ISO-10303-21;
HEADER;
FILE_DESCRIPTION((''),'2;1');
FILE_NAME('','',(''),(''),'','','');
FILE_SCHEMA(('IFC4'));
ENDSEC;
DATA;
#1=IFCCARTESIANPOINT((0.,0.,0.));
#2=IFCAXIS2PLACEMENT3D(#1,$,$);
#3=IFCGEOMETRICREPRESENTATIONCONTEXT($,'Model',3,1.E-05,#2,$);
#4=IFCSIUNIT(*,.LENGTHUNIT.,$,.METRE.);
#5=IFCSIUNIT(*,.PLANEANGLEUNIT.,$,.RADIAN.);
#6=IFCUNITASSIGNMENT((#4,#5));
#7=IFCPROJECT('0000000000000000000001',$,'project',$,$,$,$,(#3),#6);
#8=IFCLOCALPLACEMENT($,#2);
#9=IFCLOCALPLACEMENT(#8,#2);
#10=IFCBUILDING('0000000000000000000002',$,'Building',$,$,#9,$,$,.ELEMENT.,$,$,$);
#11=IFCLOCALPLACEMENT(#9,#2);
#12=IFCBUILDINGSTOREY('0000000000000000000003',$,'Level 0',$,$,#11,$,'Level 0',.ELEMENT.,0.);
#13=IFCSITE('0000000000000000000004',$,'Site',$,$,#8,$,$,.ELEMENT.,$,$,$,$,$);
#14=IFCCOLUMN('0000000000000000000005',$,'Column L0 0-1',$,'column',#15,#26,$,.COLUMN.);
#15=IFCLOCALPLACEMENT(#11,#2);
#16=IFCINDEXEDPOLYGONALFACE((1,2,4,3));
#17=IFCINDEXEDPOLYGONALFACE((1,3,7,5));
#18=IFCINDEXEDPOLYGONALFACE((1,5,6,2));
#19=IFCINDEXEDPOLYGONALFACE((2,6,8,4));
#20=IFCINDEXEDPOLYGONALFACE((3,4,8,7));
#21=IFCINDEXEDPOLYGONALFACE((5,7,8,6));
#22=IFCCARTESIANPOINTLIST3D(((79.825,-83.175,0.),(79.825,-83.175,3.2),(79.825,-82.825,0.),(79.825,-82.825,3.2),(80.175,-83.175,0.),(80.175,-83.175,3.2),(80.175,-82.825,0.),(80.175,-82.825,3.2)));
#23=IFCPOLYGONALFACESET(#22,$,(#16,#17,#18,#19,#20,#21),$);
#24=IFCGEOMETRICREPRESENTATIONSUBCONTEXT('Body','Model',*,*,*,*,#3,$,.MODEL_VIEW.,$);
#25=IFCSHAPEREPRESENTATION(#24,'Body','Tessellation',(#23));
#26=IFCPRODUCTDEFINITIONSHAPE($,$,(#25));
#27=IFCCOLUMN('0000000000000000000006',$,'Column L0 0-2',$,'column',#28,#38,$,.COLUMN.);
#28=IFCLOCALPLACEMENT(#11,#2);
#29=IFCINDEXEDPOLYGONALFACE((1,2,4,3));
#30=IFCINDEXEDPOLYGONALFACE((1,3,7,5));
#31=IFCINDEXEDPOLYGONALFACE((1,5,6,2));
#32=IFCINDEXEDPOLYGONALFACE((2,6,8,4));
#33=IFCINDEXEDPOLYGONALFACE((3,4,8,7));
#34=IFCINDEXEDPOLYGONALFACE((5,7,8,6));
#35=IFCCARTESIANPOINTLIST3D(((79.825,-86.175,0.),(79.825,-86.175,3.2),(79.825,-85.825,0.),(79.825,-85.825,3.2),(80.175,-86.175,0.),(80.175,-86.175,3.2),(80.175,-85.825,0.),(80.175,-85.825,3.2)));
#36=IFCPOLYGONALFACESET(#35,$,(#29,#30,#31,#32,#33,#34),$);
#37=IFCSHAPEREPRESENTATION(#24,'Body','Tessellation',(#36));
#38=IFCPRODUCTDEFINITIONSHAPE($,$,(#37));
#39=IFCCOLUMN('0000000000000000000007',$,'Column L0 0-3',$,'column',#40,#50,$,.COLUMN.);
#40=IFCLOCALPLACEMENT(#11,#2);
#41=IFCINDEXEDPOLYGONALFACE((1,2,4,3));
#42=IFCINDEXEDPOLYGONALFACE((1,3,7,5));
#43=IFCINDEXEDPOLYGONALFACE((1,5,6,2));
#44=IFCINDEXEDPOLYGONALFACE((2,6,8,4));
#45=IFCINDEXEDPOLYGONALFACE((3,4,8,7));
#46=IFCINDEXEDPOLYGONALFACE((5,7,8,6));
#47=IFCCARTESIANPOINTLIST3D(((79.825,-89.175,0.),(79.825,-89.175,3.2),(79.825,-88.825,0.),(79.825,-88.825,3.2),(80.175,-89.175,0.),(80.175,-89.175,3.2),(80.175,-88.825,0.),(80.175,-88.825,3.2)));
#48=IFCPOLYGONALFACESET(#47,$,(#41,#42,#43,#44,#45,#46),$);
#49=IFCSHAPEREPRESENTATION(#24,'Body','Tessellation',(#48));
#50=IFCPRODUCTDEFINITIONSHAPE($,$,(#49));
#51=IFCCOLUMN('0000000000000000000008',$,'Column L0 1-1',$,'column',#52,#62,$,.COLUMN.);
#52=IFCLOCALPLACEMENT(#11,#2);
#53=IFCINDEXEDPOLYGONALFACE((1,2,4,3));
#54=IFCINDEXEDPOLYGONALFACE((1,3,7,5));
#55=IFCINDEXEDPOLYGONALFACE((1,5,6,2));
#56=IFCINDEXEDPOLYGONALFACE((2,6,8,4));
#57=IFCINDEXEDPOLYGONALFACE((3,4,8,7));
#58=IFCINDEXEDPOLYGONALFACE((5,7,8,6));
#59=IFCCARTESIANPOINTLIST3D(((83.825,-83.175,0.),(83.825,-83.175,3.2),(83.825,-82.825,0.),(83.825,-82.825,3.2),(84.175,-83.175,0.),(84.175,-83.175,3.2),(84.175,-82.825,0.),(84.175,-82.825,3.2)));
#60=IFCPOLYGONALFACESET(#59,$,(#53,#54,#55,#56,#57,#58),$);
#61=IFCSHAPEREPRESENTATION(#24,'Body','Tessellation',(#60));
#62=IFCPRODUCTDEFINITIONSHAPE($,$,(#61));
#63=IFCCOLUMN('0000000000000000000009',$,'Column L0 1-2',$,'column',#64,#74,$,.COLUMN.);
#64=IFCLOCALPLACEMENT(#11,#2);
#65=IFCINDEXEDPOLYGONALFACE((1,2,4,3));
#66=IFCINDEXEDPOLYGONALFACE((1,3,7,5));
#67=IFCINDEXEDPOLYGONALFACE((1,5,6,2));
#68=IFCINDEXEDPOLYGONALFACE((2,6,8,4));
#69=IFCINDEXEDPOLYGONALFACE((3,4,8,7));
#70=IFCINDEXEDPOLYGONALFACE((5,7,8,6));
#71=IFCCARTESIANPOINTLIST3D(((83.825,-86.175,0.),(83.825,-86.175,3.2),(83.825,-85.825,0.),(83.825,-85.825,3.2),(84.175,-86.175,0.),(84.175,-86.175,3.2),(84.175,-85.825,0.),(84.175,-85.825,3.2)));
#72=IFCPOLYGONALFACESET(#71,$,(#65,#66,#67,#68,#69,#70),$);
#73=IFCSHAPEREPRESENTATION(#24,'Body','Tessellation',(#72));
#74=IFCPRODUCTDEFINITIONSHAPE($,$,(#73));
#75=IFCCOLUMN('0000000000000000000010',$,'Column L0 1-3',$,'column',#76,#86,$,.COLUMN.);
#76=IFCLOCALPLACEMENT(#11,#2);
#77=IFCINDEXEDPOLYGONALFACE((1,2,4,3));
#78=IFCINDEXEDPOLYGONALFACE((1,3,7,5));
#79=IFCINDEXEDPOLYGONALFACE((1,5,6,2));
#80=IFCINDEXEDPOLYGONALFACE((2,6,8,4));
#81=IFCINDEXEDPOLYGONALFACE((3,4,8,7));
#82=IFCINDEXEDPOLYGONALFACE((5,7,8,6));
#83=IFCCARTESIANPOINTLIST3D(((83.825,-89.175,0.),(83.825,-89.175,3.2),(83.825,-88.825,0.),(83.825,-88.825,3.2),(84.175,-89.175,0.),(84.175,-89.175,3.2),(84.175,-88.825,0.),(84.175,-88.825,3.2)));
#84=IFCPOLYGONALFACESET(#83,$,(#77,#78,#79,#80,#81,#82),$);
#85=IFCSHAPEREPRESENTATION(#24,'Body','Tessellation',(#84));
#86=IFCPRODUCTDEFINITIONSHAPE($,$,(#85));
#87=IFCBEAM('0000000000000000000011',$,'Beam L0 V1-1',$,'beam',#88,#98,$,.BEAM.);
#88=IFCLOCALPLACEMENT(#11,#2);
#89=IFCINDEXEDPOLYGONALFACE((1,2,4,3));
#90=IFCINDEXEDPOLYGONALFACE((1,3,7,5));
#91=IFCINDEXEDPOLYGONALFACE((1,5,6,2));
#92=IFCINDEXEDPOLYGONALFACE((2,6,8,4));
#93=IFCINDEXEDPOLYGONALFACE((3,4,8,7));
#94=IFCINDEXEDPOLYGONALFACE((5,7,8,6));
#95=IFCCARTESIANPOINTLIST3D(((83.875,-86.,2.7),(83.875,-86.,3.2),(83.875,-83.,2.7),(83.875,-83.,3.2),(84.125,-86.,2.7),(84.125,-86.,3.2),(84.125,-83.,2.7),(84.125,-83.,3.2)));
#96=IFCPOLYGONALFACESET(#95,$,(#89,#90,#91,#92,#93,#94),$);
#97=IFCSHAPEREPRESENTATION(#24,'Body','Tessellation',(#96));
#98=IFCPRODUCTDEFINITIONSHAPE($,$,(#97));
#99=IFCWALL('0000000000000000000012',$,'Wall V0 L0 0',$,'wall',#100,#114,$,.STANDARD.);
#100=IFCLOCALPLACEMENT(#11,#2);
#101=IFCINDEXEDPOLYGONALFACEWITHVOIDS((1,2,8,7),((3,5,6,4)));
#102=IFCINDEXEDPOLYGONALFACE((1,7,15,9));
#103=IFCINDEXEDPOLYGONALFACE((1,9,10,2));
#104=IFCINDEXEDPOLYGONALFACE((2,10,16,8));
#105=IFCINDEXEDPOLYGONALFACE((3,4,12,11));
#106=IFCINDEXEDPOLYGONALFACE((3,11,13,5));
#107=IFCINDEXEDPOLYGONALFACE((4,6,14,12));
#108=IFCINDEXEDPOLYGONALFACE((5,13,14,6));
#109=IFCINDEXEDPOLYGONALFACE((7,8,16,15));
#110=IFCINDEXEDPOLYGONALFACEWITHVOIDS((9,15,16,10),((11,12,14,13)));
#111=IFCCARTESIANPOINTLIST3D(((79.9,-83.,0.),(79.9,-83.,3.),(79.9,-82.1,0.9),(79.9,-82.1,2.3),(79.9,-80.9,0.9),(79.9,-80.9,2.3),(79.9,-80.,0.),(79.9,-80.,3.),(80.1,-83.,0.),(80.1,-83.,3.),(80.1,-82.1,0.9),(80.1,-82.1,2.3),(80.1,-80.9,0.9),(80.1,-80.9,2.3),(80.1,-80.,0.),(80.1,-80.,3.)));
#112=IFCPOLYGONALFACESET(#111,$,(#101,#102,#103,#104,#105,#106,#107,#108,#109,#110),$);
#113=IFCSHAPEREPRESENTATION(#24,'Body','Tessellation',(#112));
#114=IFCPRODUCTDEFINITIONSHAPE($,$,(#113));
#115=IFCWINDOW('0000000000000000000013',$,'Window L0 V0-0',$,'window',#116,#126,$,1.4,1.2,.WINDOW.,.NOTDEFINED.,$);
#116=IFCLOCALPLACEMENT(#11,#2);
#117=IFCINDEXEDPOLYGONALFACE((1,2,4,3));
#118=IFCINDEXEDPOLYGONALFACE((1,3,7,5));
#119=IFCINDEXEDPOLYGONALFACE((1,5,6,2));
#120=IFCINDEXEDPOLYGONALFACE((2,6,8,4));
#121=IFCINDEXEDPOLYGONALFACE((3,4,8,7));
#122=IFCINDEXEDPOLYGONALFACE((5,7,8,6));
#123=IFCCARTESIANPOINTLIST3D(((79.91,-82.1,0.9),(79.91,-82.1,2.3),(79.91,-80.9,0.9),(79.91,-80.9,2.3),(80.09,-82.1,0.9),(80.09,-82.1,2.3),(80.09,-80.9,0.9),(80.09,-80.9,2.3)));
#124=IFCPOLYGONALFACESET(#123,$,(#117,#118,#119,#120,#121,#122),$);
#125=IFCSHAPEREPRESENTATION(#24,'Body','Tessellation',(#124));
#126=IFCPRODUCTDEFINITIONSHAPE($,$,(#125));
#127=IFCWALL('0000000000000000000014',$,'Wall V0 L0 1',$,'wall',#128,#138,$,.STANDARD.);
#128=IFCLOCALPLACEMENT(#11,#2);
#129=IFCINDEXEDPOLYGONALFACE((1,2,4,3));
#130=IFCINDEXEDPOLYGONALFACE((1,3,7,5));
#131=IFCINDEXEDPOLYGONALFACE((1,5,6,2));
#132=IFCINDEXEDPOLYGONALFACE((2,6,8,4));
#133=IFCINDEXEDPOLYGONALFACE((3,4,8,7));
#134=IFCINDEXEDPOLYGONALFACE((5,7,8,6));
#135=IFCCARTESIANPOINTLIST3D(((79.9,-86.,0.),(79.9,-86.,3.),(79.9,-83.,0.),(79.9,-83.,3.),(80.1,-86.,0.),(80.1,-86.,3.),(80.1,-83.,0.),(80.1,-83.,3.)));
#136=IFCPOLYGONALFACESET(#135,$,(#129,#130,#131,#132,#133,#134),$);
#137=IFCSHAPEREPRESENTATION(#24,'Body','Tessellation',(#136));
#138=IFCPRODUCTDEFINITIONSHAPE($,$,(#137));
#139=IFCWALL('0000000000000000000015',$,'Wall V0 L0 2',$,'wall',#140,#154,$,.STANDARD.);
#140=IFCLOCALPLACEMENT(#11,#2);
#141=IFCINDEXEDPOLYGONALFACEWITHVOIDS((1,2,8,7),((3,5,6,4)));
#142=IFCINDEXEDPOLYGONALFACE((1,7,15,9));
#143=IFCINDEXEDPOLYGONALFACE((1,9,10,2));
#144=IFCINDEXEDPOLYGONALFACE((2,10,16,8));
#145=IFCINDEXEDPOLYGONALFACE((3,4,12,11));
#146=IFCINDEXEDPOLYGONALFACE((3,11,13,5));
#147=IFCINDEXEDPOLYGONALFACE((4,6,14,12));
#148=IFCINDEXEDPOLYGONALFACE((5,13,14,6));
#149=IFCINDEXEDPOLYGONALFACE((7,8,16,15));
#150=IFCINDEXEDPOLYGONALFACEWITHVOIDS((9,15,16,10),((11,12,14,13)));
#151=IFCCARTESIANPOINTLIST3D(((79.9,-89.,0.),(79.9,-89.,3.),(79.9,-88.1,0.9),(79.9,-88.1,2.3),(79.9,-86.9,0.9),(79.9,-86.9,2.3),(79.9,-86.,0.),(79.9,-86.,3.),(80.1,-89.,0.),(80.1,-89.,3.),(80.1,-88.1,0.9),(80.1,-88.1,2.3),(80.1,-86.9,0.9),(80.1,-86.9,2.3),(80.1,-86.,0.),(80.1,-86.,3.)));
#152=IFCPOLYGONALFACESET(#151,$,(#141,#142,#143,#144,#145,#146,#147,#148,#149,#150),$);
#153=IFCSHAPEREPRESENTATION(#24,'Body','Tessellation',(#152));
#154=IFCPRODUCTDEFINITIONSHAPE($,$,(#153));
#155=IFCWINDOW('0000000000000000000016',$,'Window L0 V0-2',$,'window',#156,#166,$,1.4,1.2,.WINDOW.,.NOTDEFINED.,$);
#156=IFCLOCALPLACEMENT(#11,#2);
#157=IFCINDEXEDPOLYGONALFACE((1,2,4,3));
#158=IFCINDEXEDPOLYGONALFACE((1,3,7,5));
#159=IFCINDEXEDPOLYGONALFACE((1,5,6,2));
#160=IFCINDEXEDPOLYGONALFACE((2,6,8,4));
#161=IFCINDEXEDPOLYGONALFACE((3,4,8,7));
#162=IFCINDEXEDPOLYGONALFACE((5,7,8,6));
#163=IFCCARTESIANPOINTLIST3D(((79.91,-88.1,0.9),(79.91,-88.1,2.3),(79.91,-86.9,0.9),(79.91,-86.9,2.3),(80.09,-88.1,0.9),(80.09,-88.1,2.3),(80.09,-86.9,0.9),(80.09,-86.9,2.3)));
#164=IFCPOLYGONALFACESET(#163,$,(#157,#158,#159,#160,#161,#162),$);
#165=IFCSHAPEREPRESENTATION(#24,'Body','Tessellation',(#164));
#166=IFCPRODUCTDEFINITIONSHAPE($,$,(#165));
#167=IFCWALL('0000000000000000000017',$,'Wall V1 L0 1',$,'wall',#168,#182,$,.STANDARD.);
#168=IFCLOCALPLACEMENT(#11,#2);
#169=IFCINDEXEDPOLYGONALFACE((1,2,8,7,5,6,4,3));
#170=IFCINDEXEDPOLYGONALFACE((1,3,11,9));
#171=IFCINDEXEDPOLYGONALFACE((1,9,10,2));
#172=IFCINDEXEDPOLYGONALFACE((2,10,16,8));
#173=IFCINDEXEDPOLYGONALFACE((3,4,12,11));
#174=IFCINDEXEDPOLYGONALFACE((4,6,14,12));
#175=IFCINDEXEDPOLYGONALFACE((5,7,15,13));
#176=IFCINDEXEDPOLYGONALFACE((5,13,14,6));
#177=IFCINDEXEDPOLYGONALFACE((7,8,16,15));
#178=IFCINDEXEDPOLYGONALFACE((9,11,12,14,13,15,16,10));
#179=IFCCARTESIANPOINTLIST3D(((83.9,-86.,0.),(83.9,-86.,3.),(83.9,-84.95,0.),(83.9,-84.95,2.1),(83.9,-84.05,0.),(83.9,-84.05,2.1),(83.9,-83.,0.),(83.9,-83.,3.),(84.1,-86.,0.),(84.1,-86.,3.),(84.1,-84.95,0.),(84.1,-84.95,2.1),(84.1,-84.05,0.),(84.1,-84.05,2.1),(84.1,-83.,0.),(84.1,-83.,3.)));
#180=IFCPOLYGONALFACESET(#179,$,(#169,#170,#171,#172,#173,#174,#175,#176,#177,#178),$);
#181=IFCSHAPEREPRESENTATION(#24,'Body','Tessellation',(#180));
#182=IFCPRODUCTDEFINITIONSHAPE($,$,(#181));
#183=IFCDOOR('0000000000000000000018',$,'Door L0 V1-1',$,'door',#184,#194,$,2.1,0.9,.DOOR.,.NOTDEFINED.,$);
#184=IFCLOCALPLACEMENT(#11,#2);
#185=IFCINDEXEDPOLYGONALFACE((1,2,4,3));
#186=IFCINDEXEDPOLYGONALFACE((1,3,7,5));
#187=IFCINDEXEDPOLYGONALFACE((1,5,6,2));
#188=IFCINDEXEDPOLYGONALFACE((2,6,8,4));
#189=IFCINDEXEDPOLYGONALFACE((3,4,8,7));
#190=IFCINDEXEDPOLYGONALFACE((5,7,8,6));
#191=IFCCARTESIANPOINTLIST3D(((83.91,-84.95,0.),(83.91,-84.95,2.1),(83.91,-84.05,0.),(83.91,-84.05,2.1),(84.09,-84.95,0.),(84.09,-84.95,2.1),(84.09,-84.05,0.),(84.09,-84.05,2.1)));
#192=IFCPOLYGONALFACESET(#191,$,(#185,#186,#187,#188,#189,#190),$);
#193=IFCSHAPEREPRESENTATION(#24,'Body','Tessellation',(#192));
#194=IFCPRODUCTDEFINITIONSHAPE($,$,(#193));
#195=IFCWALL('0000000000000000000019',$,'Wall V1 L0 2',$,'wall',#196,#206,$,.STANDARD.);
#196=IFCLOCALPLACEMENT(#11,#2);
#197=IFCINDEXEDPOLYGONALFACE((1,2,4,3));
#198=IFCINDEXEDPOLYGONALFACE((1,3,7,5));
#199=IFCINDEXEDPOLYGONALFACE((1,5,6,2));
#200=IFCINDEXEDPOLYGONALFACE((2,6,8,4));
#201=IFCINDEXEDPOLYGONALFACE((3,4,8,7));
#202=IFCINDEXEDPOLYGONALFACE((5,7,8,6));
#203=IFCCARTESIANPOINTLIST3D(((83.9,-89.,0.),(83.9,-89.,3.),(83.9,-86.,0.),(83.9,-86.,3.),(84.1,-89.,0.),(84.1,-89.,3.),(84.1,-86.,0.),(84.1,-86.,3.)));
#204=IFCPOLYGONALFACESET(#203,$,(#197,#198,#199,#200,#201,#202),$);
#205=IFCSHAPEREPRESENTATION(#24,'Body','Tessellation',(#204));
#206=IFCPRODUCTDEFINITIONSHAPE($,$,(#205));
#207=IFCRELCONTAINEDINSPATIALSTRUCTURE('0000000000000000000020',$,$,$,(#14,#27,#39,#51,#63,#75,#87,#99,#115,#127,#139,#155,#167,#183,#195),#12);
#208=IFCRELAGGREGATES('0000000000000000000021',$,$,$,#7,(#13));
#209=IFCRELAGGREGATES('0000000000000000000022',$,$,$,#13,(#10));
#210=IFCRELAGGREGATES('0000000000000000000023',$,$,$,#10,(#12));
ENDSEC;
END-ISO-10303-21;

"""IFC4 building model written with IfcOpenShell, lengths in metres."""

from ifc_helpers import new_model, si_unit, frame, frame_2d, origin, origin_2d, place, context, subcontext, project, spatial, rectangle, extrude, element, fill, save


model = new_model("IFC4")

# Units and contexts
model_context = context("Model", 3, precision=1e-05, world=origin())
body_context = subcontext(model_context, "Body", "Model", "MODEL_VIEW")
ifc_project = project(units=[si_unit("LENGTHUNIT", "METRE"), si_unit("PLANEANGLEUNIT", "RADIAN")], contexts=[model_context])

# Site, building, storey
site_placement = place(None, origin())
site = spatial("IfcSite", under=ifc_project, at=site_placement, Name="Site", CompositionType="ELEMENT")
building_placement = place(site_placement, origin())
building = spatial("IfcBuilding", under=site, at=building_placement, Name="Building", CompositionType="ELEMENT")
storey_placement = place(building_placement, origin())
storey = spatial("IfcBuildingStorey", under=building, at=storey_placement, Name="Level 0", LongName="Level 0", CompositionType="ELEMENT", Elevation=0.0)

# Columns
for number, where, name in (
    (1, (80.0, -83.0, 0.0), "Column L0 0-1"),
    (2, (80.0, -86.0, 0.0), "Column L0 0-2"),
    (3, (80.0, -89.0, 0.0), "Column L0 0-3"),
    (4, (84.0, -83.0, 0.0), "Column L0 1-1"),
    (5, (84.0, -86.0, 0.0), "Column L0 1-2"),
    (6, (84.0, -89.0, 0.0), "Column L0 1-3"),
):
    element("IfcColumn", number, at=place(storey_placement, frame(where)), inside=storey, Name=name, ObjectType="column", PredefinedType="COLUMN", context=body_context, shape_type="SweptSolid", body=[
        extrude(rectangle(XDim=0.35, YDim=0.35, at=origin_2d()), origin(), (0.0, 0.0, 1.0), 3.2),
    ])

# Beam
beam_placement = place(storey_placement, frame((84.0, -83.0, 2.95), z_axis=(0.0, -1.0, 0.0), x_axis=(0.0, 0.0, 1.0)))
element("IfcBeam", 7, at=beam_placement, inside=storey, Name="Beam L0 V1-1", ObjectType="beam", PredefinedType="BEAM", context=body_context, shape_type="SweptSolid", body=[
    extrude(rectangle(XDim=0.5, YDim=0.25, at=origin_2d()), origin(), (0.0, 0.0, 1.0), 3.0),
])

# Wall, opening, window
wall_1_placement = place(storey_placement, frame((80.0, -80.0, 0.0), z_axis=(0.0, 0.0, 1.0), x_axis=(0.0, -1.0, 0.0)))
wall_1 = element("IfcWall", 8, at=wall_1_placement, inside=storey, Name="Wall V0 L0 0", ObjectType="wall", PredefinedType="STANDARD", context=body_context, shape_type="SweptSolid", body=[
    extrude(rectangle(XDim=3.0, YDim=0.2, at=frame_2d((1.5, 0.0))), origin(), (0.0, 0.0, 1.0), 3.0),
])
opening_1_placement = place(storey_placement, frame((80.0, -81.5, 0.9), z_axis=(0.0, 0.0, 1.0), x_axis=(0.0, -1.0, 0.0)))
opening_1 = element("IfcOpeningElement", 9, at=opening_1_placement, cuts=wall_1, ObjectType="Opening", PredefinedType="OPENING", context=body_context, shape_type="SweptSolid", body=[
    extrude(rectangle(XDim=1.2, YDim=0.22, at=origin_2d()), origin(), (0.0, 0.0, 1.0), 1.4),
])
window_1_placement = place(storey_placement, frame((80.0, -81.5, 0.9), z_axis=(0.0, 0.0, 1.0), x_axis=(0.0, -1.0, 0.0)))
window_1 = element("IfcWindow", 10, at=window_1_placement, inside=storey, Name="Window L0 V0-0", ObjectType="window", OverallHeight=1.4, OverallWidth=1.2, PartitioningType="NOTDEFINED", PredefinedType="WINDOW", context=body_context, shape_type="SweptSolid", body=[
    extrude(rectangle(XDim=1.2, YDim=0.18, at=origin_2d()), origin(), (0.0, 0.0, 1.0), 1.4),
])
fill(opening_1, window_1)

# Wall
wall_2_placement = place(storey_placement, frame((80.0, -83.0, 0.0), z_axis=(0.0, 0.0, 1.0), x_axis=(0.0, -1.0, 0.0)))
element("IfcWall", 11, at=wall_2_placement, inside=storey, Name="Wall V0 L0 1", ObjectType="wall", PredefinedType="STANDARD", context=body_context, shape_type="SweptSolid", body=[
    extrude(rectangle(XDim=3.0, YDim=0.2, at=frame_2d((1.5, 0.0))), origin(), (0.0, 0.0, 1.0), 3.0),
])

# Wall, opening, window
wall_3_placement = place(storey_placement, frame((80.0, -86.0, 0.0), z_axis=(0.0, 0.0, 1.0), x_axis=(0.0, -1.0, 0.0)))
wall_3 = element("IfcWall", 12, at=wall_3_placement, inside=storey, Name="Wall V0 L0 2", ObjectType="wall", PredefinedType="STANDARD", context=body_context, shape_type="SweptSolid", body=[
    extrude(rectangle(XDim=3.0, YDim=0.2, at=frame_2d((1.5, 0.0))), origin(), (0.0, 0.0, 1.0), 3.0),
])
opening_2_placement = place(storey_placement, frame((80.0, -87.5, 0.9), z_axis=(0.0, 0.0, 1.0), x_axis=(0.0, -1.0, 0.0)))
opening_2 = element("IfcOpeningElement", 13, at=opening_2_placement, cuts=wall_3, ObjectType="Opening", PredefinedType="OPENING", context=body_context, shape_type="SweptSolid", body=[
    extrude(rectangle(XDim=1.2, YDim=0.22, at=origin_2d()), origin(), (0.0, 0.0, 1.0), 1.4),
])
window_2_placement = place(storey_placement, frame((80.0, -87.5, 0.9), z_axis=(0.0, 0.0, 1.0), x_axis=(0.0, -1.0, 0.0)))
window_2 = element("IfcWindow", 14, at=window_2_placement, inside=storey, Name="Window L0 V0-2", ObjectType="window", OverallHeight=1.4, OverallWidth=1.2, PartitioningType="NOTDEFINED", PredefinedType="WINDOW", context=body_context, shape_type="SweptSolid", body=[
    extrude(rectangle(XDim=1.2, YDim=0.18, at=origin_2d()), origin(), (0.0, 0.0, 1.0), 1.4),
])
fill(opening_2, window_2)

# Wall, opening, door
wall_4_placement = place(storey_placement, frame((84.0, -83.0, 0.0), z_axis=(0.0, 0.0, 1.0), x_axis=(0.0, -1.0, 0.0)))
wall_4 = element("IfcWall", 15, at=wall_4_placement, inside=storey, Name="Wall V1 L0 1", ObjectType="wall", PredefinedType="STANDARD", context=body_context, shape_type="SweptSolid", body=[
    extrude(rectangle(XDim=3.0, YDim=0.2, at=frame_2d((1.5, 0.0))), origin(), (0.0, 0.0, 1.0), 3.0),
])
opening_3_placement = place(storey_placement, frame((84.0, -84.5, 0.0), z_axis=(0.0, 0.0, 1.0), x_axis=(0.0, -1.0, 0.0)))
opening_3 = element("IfcOpeningElement", 16, at=opening_3_placement, cuts=wall_4, ObjectType="Opening", PredefinedType="OPENING", context=body_context, shape_type="SweptSolid", body=[
    extrude(rectangle(XDim=0.9, YDim=0.22, at=origin_2d()), origin(), (0.0, 0.0, 1.0), 2.1),
])
door_placement = place(storey_placement, frame((84.0, -84.5, 0.0), z_axis=(0.0, 0.0, 1.0), x_axis=(0.0, -1.0, 0.0)))
door = element("IfcDoor", 17, at=door_placement, inside=storey, Name="Door L0 V1-1", ObjectType="door", OperationType="NOTDEFINED", OverallHeight=2.1, OverallWidth=0.9, PredefinedType="DOOR", context=body_context, shape_type="SweptSolid", body=[
    extrude(rectangle(XDim=0.9, YDim=0.18, at=origin_2d()), origin(), (0.0, 0.0, 1.0), 2.1),
])
fill(opening_3, door)

# Wall
wall_5_placement = place(storey_placement, frame((84.0, -86.0, 0.0), z_axis=(0.0, 0.0, 1.0), x_axis=(0.0, -1.0, 0.0)))
element("IfcWall", 18, at=wall_5_placement, inside=storey, Name="Wall V1 L0 2", ObjectType="wall", PredefinedType="STANDARD", context=body_context, shape_type="SweptSolid", body=[
    extrude(rectangle(XDim=3.0, YDim=0.2, at=frame_2d((1.5, 0.0))), origin(), (0.0, 0.0, 1.0), 3.0),
])

save(model, "model.ifc")
